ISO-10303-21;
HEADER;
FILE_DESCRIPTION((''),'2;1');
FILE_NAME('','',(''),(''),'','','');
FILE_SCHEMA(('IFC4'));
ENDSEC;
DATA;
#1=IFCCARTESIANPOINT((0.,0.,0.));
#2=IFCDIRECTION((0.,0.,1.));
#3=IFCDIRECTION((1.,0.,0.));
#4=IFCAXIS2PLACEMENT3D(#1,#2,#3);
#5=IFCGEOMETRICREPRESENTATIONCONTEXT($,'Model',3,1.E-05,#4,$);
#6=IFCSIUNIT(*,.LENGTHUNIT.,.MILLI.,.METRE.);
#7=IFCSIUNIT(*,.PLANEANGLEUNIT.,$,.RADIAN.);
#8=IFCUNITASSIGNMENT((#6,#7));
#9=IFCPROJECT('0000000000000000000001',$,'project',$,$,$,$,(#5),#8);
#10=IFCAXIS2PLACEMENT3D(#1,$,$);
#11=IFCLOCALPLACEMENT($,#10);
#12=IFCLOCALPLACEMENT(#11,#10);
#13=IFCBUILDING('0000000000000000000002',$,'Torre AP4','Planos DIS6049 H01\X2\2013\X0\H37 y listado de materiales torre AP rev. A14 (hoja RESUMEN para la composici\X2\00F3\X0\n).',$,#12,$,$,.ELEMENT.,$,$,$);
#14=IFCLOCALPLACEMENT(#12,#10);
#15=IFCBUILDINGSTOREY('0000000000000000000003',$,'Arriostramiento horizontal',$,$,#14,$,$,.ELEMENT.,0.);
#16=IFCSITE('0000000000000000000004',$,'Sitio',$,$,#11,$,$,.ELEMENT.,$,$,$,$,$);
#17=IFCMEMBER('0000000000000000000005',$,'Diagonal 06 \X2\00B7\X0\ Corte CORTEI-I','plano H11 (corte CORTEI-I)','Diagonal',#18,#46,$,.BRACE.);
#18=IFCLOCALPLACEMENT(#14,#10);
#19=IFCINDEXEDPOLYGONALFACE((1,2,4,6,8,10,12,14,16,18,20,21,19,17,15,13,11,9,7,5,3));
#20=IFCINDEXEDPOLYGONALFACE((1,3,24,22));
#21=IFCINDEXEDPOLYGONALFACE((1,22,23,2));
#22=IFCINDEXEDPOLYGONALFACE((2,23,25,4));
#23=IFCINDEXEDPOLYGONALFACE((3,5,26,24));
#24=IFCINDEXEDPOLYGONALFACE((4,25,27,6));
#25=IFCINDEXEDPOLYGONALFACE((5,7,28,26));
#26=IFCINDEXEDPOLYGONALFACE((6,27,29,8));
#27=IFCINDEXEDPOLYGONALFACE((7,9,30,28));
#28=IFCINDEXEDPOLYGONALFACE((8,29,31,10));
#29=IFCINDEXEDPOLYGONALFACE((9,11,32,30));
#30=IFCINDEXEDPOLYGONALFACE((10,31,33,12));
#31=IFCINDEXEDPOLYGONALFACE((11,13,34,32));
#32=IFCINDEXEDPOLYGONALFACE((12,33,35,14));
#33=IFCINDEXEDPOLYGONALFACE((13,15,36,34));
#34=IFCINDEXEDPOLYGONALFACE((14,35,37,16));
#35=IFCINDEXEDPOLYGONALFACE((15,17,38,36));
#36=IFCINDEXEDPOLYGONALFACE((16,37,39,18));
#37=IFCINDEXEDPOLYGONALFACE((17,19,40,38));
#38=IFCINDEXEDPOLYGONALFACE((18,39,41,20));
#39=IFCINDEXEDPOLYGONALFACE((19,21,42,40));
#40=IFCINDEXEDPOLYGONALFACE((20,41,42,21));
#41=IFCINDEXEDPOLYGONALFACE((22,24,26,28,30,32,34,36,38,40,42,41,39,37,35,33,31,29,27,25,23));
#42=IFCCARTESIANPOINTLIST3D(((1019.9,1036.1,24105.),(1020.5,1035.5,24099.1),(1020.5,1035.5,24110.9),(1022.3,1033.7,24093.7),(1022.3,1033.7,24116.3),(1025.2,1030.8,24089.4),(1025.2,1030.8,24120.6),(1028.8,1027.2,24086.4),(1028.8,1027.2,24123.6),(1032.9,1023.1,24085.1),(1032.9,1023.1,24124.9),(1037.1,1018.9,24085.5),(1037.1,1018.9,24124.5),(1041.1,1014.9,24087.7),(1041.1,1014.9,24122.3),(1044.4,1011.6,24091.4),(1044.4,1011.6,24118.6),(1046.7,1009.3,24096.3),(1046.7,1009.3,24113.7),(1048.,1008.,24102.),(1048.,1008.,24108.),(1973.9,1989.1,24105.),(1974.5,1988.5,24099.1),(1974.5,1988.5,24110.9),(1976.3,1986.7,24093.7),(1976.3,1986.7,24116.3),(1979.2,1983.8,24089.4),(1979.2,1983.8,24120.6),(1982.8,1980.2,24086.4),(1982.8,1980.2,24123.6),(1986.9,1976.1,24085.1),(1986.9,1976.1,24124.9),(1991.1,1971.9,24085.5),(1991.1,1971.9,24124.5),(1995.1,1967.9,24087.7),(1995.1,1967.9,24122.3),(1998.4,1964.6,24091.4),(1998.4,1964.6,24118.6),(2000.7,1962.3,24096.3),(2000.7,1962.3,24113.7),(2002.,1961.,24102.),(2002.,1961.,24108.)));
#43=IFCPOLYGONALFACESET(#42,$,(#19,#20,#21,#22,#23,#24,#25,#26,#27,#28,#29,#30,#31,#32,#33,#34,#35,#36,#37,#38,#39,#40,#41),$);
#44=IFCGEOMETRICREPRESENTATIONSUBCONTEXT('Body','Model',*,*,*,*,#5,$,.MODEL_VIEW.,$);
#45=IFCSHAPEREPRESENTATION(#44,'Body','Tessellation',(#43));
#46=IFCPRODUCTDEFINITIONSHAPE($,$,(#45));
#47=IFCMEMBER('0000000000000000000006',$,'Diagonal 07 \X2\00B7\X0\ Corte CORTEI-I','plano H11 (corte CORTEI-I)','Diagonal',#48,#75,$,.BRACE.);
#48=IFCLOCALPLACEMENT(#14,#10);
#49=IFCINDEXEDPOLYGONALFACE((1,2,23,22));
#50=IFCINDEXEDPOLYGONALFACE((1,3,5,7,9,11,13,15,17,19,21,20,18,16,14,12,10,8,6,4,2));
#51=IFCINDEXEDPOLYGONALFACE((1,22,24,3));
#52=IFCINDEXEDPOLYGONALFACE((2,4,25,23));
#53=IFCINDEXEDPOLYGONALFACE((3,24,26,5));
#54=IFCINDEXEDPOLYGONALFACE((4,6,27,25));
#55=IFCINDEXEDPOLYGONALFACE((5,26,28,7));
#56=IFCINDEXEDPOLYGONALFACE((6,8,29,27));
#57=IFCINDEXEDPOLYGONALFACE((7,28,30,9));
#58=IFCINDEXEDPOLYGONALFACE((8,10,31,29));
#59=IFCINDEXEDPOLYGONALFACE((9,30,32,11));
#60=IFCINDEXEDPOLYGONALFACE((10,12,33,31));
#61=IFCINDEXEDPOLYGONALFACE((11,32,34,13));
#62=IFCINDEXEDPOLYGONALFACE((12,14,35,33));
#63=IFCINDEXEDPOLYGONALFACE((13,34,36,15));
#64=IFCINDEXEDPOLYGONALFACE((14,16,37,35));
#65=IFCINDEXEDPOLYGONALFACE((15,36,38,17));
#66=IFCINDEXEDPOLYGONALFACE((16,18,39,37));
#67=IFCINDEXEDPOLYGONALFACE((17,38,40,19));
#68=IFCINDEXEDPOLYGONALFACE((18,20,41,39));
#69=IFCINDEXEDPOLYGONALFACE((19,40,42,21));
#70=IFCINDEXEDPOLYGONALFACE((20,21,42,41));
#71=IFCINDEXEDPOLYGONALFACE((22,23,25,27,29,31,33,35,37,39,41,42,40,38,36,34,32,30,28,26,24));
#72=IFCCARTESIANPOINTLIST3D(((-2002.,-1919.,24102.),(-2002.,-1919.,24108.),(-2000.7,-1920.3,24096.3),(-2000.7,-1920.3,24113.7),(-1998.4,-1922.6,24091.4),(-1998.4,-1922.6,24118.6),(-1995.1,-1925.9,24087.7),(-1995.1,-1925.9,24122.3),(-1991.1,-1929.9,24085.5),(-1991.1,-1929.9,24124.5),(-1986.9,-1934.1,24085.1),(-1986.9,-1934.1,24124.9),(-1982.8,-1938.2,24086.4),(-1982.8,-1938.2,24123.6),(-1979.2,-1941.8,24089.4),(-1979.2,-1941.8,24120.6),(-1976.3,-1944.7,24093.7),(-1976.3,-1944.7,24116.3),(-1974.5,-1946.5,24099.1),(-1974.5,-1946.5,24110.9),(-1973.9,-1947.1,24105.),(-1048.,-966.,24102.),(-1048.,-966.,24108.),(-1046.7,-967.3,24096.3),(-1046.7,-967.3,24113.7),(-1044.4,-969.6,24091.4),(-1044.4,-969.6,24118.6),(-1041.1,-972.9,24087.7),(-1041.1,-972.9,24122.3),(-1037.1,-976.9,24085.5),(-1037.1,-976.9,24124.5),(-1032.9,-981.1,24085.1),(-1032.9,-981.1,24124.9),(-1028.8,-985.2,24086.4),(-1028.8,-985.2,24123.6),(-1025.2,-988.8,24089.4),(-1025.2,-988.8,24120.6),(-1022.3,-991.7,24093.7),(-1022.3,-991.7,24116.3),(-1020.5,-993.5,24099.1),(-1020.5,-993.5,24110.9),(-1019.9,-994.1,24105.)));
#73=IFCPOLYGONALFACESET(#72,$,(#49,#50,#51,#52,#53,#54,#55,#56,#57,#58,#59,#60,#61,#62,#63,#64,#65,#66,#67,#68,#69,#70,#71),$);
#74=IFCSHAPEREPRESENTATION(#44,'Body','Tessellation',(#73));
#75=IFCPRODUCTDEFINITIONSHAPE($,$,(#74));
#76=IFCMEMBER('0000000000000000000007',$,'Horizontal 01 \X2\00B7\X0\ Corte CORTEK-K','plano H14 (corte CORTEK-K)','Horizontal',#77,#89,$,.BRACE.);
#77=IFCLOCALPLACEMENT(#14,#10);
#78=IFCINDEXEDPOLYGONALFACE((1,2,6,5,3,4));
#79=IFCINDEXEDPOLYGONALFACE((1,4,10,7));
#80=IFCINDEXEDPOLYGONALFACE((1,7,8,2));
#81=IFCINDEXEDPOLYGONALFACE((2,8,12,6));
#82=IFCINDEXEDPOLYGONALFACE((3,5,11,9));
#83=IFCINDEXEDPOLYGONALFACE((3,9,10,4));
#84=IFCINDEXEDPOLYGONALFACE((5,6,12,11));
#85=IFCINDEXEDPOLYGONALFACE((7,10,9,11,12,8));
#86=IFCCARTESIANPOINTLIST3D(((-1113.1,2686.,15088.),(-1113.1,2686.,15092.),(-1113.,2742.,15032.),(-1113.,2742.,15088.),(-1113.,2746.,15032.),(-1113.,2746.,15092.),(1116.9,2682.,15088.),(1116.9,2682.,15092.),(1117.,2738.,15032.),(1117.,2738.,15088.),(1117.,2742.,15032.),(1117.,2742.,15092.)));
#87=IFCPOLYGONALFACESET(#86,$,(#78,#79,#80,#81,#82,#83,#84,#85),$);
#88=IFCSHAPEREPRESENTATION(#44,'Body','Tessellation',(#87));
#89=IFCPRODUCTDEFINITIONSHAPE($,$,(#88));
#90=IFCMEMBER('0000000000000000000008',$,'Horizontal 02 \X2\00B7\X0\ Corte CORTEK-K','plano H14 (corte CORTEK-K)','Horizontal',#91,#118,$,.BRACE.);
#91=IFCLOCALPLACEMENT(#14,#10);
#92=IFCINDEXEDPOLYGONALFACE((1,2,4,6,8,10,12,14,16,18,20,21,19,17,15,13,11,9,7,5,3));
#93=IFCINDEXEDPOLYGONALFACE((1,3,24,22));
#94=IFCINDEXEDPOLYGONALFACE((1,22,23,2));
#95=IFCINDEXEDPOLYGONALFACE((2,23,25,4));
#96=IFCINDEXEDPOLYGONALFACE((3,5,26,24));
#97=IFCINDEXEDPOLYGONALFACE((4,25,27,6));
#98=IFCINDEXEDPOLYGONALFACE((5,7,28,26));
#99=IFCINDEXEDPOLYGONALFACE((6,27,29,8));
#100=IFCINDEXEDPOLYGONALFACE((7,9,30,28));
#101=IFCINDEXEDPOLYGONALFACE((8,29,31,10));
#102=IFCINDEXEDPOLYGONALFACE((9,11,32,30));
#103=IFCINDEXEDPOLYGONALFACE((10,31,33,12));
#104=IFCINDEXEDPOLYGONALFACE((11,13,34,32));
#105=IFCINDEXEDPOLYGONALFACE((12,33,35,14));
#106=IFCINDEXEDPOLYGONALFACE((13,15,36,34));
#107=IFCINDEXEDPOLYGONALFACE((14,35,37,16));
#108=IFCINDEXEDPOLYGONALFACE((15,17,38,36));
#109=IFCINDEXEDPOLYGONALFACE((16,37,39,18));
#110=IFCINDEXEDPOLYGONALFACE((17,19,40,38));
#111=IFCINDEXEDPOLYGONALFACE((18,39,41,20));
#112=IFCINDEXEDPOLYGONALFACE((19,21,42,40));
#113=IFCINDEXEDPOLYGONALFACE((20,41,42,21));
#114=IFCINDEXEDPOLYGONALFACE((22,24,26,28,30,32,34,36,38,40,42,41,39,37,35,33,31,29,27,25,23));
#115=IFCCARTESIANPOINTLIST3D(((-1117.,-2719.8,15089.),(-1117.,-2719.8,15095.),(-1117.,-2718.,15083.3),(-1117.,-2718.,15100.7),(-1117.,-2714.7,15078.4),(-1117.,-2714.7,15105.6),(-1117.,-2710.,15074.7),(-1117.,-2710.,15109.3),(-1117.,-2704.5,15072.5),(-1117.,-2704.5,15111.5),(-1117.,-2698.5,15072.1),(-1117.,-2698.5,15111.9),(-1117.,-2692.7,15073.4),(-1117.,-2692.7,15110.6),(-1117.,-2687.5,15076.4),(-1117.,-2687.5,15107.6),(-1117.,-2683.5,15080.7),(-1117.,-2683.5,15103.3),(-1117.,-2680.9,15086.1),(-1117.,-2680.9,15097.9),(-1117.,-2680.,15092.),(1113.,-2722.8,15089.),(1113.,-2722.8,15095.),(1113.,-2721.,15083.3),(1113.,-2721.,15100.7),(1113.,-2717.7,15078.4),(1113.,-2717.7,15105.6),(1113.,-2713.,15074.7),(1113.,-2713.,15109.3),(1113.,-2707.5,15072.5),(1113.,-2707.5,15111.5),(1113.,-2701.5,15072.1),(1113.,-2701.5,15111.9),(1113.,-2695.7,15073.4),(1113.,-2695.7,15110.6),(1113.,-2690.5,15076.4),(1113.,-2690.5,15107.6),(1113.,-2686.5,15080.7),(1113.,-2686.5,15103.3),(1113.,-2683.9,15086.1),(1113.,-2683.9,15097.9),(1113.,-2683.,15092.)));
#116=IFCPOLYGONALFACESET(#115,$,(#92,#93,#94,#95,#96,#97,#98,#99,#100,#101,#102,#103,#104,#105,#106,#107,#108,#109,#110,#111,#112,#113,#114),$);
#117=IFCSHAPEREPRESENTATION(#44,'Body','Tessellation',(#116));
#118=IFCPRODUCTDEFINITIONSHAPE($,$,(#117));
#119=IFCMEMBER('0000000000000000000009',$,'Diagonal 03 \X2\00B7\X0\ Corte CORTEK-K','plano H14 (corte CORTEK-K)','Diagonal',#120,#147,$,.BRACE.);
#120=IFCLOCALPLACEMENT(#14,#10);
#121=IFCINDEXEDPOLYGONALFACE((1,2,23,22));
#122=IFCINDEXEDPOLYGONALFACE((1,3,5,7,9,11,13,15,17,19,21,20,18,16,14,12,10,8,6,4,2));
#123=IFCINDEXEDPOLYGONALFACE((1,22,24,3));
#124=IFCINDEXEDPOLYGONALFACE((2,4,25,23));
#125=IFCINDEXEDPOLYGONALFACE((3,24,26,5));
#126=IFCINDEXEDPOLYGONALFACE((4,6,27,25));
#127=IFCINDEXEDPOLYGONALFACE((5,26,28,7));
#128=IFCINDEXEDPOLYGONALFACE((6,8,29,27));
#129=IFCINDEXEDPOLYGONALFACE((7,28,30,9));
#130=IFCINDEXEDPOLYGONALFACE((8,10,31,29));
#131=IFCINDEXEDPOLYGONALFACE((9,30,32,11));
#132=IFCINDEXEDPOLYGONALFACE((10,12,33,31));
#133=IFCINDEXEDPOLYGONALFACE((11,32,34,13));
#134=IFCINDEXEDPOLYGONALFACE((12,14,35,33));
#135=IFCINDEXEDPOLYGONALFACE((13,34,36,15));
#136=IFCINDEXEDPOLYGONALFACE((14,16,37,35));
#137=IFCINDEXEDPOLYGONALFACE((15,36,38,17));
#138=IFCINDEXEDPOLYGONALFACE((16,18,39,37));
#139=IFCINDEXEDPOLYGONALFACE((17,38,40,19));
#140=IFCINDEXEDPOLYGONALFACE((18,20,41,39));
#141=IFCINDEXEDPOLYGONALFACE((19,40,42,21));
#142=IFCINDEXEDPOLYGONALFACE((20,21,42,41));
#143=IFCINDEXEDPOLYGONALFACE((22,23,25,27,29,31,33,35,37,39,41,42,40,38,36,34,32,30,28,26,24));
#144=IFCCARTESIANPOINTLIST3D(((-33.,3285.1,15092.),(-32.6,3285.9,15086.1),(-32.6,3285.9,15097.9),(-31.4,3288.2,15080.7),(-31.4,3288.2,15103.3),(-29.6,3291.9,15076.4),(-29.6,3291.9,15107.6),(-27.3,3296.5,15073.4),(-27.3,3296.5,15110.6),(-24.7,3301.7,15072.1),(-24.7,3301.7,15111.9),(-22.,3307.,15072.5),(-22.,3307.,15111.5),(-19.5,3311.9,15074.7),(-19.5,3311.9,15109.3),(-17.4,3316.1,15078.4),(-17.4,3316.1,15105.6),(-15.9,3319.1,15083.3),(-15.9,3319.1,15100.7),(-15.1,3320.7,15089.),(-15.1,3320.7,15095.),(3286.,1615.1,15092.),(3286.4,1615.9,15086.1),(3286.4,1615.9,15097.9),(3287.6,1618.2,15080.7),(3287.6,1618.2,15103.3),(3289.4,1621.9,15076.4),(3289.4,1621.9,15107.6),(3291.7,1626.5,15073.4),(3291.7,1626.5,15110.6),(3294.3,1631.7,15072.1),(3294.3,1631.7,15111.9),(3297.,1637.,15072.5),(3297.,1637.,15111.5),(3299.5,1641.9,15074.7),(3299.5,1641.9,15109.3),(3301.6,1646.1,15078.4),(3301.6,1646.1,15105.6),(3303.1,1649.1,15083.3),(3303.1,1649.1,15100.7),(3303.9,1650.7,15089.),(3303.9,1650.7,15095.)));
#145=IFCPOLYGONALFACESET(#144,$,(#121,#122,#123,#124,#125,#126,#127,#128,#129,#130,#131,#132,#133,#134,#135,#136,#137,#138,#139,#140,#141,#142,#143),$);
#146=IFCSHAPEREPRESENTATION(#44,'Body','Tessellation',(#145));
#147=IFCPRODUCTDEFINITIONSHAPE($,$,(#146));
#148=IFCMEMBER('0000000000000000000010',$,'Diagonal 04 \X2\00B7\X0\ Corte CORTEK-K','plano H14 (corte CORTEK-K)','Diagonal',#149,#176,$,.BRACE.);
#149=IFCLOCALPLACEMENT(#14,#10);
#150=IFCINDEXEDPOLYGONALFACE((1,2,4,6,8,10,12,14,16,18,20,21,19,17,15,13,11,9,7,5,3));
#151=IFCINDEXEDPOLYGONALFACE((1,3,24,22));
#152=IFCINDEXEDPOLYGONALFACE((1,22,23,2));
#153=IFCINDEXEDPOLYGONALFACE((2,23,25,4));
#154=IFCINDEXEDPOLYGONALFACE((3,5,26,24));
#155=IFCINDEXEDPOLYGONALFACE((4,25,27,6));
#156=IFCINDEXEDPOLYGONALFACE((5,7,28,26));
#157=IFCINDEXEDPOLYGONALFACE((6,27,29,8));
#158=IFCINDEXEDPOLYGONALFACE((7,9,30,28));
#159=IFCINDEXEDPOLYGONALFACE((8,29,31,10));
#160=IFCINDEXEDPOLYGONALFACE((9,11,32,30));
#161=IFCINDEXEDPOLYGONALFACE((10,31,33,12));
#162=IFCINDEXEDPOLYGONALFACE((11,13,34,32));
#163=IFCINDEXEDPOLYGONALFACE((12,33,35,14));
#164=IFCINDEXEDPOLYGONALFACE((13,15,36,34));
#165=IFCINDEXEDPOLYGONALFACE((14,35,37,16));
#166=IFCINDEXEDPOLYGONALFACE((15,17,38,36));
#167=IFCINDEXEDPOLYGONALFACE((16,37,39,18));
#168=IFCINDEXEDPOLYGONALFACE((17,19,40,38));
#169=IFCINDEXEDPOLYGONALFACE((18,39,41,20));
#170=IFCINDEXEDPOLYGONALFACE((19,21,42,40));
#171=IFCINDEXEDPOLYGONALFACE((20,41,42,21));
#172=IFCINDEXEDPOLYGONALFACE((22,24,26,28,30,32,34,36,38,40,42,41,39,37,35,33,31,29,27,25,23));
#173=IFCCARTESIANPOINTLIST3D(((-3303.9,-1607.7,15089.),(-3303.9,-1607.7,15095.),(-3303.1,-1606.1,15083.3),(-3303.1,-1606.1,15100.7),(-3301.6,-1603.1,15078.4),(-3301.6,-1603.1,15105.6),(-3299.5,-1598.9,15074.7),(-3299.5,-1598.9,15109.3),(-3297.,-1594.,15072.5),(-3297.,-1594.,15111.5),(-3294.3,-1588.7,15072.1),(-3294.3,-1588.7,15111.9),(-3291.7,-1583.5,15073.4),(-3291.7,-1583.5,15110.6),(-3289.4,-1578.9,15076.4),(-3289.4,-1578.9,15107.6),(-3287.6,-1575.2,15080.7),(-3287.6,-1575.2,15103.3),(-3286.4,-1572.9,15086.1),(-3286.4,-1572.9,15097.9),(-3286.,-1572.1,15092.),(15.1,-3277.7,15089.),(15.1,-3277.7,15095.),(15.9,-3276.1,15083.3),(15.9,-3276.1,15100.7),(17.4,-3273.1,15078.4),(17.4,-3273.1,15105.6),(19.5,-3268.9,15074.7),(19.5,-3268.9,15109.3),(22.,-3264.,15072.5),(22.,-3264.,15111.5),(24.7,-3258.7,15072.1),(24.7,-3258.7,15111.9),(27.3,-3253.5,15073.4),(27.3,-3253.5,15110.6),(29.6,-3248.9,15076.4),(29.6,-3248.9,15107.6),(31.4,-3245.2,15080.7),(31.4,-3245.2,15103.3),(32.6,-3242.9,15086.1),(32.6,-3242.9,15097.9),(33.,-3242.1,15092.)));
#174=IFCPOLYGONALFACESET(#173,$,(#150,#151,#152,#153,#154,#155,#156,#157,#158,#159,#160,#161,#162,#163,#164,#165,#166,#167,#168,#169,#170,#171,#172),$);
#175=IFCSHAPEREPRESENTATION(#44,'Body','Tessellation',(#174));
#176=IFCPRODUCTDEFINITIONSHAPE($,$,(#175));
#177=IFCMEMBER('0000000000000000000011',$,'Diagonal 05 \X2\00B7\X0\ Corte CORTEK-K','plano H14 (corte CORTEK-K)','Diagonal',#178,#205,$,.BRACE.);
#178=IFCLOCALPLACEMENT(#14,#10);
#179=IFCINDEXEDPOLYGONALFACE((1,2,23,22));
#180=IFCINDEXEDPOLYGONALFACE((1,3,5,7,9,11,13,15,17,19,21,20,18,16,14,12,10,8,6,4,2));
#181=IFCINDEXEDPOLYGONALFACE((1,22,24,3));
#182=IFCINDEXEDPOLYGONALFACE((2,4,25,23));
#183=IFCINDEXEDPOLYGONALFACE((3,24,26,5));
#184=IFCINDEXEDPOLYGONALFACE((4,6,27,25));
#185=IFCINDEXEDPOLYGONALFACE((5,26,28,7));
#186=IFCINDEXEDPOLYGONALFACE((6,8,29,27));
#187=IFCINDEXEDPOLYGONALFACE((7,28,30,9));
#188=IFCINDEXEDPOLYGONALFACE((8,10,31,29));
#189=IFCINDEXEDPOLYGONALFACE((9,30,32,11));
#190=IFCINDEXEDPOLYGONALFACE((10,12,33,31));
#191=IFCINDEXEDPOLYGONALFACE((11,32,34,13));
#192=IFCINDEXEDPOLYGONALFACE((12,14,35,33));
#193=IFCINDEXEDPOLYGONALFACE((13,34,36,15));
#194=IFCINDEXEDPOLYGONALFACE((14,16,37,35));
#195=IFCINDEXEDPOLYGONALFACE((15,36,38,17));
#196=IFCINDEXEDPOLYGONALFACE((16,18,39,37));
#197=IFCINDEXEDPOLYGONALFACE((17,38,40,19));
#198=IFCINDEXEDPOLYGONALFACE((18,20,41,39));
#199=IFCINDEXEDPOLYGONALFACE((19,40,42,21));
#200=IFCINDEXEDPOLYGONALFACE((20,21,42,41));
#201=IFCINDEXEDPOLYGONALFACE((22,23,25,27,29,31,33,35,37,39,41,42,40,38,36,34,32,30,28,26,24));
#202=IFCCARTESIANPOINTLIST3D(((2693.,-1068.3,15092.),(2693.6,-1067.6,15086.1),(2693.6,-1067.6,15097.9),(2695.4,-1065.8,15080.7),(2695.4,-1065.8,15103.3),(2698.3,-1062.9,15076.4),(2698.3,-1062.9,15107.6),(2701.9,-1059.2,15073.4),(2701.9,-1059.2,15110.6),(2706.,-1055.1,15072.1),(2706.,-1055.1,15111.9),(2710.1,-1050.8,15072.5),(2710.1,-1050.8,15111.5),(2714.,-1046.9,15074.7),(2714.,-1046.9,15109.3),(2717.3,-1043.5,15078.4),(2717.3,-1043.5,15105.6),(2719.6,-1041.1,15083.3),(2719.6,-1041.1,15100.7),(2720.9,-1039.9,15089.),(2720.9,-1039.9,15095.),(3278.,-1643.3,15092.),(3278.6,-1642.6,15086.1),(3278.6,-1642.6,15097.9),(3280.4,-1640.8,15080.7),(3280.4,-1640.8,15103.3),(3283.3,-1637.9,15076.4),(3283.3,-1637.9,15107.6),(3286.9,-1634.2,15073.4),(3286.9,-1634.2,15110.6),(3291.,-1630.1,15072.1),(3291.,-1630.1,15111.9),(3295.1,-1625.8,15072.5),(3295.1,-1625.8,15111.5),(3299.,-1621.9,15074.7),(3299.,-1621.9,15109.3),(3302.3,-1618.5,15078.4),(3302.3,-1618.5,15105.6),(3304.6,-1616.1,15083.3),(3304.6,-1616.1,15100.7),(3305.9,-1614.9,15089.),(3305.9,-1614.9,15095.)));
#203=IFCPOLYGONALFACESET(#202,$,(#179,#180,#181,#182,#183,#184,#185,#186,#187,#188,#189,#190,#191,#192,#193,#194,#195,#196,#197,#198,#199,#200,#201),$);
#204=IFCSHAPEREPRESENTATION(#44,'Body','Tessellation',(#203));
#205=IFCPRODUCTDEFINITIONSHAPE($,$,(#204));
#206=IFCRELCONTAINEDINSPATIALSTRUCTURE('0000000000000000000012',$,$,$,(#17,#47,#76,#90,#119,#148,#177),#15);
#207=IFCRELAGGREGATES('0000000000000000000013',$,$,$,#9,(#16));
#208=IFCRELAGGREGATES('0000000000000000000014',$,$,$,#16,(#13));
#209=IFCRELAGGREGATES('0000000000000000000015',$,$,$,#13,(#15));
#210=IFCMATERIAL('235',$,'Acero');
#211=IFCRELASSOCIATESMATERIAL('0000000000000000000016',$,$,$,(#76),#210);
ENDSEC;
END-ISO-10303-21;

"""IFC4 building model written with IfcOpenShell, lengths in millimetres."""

from ifc_helpers import new_model, si_unit, frame, frame_2d, origin, origin_with_axes, place, context, subcontext, project, spatial, circle, l_section, extrude, material, element, save


model = new_model("IFC4")

# Units and contexts
model_context = context("Model", 3, precision=1e-05, world=origin_with_axes())
body_context = subcontext(model_context, "Body", "Model", "MODEL_VIEW")
ifc_project = project(units=[si_unit("LENGTHUNIT", "METRE", prefix="MILLI"), si_unit("PLANEANGLEUNIT", "RADIAN")], contexts=[model_context])

# Site, building, storey
site_placement = place(None, origin())
site = spatial("IfcSite", under=ifc_project, at=site_placement, Name="Sitio", CompositionType="ELEMENT")
building_placement = place(site_placement, origin())
building = spatial("IfcBuilding", under=site, at=building_placement, Name="Torre AP4", Description="Planos DIS6049 H01–H37 y listado de materiales torre AP rev. A14 (hoja RESUMEN para la composición).", CompositionType="ELEMENT")
storey_placement = place(building_placement, origin())
storey = spatial("IfcBuildingStorey", under=building, at=storey_placement, Name="Arriostramiento horizontal", CompositionType="ELEMENT", Elevation=0.0)

# Members
ifc_material = material(Name="235", Category="Acero")
for number, where, z_axis, x_axis, name in (
    (1, (1988.0, 1975.0, 24105.0), (-0.707477, -0.706736, 0.0), (-0.706736, 0.707477, 0.0), "Diagonal 06 · Corte CORTEI-I"),
    (2, (-1034.0, -980.0, 24105.0), (-0.707477, -0.706736, 0.0), (0.706736, -0.707477, 0.0), "Diagonal 07 · Corte CORTEI-I"),
):
    element("IfcMember", number, at=place(storey_placement, frame(where, z_axis=z_axis, x_axis=x_axis)), inside=storey, Name=name, Description="plano H11 (corte CORTEI-I)", ObjectType="Diagonal", PredefinedType="BRACE", context=body_context, shape_type="SweptSolid", body=[
        extrude(circle(Radius=20.0), None, (0.0, 0.0, 1.0), 1348.5),
    ])
member_1_placement = place(storey_placement, frame((-1113.0, 2746.0, 15092.0), z_axis=(0.999998, -0.001794, 0.0), x_axis=(-0.001794, -0.999998, 0.0)))
element("IfcMember", 3, at=member_1_placement, inside=storey, material=ifc_material, Name="Horizontal 01 · Corte CORTEK-K", Description="plano H14 (corte CORTEK-K)", ObjectType="Horizontal", PredefinedType="BRACE", context=body_context, shape_type="SweptSolid", body=[
    extrude(l_section(Depth=60.0, Width=60.0, Thickness=4.0, at=frame_2d((30.0, 30.0))), None, (0.0, 0.0, 1.0), 2230.0),
])
member_2_placement = place(storey_placement, frame((-1117.0, -2700.0, 15092.0), z_axis=(0.999999, -0.001345, 0.0), x_axis=(0.001345, 0.999999, 0.0)))
element("IfcMember", 4, at=member_2_placement, inside=storey, Name="Horizontal 02 · Corte CORTEK-K", Description="plano H14 (corte CORTEK-K)", ObjectType="Horizontal", PredefinedType="BRACE", context=body_context, shape_type="SweptSolid", body=[
    extrude(circle(Radius=20.0), None, (0.0, 0.0, 1.0), 2230.0),
])
for number, where, z_axis, x_axis, name in (
    (5, (-24.0, 3303.0, 15092.0), (0.893294, -0.449473, 0.0), (-0.449473, -0.893294, 0.0), "Diagonal 03 · Corte CORTEK-K"),
    (6, (-3295.0, -1590.0, 15092.0), (0.893294, -0.449473, 0.0), (0.449473, 0.893294, 0.0), "Diagonal 04 · Corte CORTEK-K"),
):
    element("IfcMember", number, at=place(storey_placement, frame(where, z_axis=z_axis, x_axis=x_axis)), inside=storey, Name=name, Description="plano H14 (corte CORTEK-K)", ObjectType="Diagonal", PredefinedType="BRACE", context=body_context, shape_type="SweptSolid", body=[
        extrude(circle(Radius=20.0), None, (0.0, 0.0, 1.0), 3715.5),
    ])
member_3_placement = place(storey_placement, frame((2707.0, -1054.0, 15092.0), z_axis=(0.713176, -0.700985, 0.0), x_axis=(-0.700985, -0.713176, 0.0)))
element("IfcMember", 7, at=member_3_placement, inside=storey, Name="Diagonal 05 · Corte CORTEK-K", Description="plano H14 (corte CORTEK-K)", ObjectType="Diagonal", PredefinedType="BRACE", context=body_context, shape_type="SweptSolid", body=[
    extrude(circle(Radius=20.0), None, (0.0, 0.0, 1.0), 820.3),
])

save(model, "model.ifc")
